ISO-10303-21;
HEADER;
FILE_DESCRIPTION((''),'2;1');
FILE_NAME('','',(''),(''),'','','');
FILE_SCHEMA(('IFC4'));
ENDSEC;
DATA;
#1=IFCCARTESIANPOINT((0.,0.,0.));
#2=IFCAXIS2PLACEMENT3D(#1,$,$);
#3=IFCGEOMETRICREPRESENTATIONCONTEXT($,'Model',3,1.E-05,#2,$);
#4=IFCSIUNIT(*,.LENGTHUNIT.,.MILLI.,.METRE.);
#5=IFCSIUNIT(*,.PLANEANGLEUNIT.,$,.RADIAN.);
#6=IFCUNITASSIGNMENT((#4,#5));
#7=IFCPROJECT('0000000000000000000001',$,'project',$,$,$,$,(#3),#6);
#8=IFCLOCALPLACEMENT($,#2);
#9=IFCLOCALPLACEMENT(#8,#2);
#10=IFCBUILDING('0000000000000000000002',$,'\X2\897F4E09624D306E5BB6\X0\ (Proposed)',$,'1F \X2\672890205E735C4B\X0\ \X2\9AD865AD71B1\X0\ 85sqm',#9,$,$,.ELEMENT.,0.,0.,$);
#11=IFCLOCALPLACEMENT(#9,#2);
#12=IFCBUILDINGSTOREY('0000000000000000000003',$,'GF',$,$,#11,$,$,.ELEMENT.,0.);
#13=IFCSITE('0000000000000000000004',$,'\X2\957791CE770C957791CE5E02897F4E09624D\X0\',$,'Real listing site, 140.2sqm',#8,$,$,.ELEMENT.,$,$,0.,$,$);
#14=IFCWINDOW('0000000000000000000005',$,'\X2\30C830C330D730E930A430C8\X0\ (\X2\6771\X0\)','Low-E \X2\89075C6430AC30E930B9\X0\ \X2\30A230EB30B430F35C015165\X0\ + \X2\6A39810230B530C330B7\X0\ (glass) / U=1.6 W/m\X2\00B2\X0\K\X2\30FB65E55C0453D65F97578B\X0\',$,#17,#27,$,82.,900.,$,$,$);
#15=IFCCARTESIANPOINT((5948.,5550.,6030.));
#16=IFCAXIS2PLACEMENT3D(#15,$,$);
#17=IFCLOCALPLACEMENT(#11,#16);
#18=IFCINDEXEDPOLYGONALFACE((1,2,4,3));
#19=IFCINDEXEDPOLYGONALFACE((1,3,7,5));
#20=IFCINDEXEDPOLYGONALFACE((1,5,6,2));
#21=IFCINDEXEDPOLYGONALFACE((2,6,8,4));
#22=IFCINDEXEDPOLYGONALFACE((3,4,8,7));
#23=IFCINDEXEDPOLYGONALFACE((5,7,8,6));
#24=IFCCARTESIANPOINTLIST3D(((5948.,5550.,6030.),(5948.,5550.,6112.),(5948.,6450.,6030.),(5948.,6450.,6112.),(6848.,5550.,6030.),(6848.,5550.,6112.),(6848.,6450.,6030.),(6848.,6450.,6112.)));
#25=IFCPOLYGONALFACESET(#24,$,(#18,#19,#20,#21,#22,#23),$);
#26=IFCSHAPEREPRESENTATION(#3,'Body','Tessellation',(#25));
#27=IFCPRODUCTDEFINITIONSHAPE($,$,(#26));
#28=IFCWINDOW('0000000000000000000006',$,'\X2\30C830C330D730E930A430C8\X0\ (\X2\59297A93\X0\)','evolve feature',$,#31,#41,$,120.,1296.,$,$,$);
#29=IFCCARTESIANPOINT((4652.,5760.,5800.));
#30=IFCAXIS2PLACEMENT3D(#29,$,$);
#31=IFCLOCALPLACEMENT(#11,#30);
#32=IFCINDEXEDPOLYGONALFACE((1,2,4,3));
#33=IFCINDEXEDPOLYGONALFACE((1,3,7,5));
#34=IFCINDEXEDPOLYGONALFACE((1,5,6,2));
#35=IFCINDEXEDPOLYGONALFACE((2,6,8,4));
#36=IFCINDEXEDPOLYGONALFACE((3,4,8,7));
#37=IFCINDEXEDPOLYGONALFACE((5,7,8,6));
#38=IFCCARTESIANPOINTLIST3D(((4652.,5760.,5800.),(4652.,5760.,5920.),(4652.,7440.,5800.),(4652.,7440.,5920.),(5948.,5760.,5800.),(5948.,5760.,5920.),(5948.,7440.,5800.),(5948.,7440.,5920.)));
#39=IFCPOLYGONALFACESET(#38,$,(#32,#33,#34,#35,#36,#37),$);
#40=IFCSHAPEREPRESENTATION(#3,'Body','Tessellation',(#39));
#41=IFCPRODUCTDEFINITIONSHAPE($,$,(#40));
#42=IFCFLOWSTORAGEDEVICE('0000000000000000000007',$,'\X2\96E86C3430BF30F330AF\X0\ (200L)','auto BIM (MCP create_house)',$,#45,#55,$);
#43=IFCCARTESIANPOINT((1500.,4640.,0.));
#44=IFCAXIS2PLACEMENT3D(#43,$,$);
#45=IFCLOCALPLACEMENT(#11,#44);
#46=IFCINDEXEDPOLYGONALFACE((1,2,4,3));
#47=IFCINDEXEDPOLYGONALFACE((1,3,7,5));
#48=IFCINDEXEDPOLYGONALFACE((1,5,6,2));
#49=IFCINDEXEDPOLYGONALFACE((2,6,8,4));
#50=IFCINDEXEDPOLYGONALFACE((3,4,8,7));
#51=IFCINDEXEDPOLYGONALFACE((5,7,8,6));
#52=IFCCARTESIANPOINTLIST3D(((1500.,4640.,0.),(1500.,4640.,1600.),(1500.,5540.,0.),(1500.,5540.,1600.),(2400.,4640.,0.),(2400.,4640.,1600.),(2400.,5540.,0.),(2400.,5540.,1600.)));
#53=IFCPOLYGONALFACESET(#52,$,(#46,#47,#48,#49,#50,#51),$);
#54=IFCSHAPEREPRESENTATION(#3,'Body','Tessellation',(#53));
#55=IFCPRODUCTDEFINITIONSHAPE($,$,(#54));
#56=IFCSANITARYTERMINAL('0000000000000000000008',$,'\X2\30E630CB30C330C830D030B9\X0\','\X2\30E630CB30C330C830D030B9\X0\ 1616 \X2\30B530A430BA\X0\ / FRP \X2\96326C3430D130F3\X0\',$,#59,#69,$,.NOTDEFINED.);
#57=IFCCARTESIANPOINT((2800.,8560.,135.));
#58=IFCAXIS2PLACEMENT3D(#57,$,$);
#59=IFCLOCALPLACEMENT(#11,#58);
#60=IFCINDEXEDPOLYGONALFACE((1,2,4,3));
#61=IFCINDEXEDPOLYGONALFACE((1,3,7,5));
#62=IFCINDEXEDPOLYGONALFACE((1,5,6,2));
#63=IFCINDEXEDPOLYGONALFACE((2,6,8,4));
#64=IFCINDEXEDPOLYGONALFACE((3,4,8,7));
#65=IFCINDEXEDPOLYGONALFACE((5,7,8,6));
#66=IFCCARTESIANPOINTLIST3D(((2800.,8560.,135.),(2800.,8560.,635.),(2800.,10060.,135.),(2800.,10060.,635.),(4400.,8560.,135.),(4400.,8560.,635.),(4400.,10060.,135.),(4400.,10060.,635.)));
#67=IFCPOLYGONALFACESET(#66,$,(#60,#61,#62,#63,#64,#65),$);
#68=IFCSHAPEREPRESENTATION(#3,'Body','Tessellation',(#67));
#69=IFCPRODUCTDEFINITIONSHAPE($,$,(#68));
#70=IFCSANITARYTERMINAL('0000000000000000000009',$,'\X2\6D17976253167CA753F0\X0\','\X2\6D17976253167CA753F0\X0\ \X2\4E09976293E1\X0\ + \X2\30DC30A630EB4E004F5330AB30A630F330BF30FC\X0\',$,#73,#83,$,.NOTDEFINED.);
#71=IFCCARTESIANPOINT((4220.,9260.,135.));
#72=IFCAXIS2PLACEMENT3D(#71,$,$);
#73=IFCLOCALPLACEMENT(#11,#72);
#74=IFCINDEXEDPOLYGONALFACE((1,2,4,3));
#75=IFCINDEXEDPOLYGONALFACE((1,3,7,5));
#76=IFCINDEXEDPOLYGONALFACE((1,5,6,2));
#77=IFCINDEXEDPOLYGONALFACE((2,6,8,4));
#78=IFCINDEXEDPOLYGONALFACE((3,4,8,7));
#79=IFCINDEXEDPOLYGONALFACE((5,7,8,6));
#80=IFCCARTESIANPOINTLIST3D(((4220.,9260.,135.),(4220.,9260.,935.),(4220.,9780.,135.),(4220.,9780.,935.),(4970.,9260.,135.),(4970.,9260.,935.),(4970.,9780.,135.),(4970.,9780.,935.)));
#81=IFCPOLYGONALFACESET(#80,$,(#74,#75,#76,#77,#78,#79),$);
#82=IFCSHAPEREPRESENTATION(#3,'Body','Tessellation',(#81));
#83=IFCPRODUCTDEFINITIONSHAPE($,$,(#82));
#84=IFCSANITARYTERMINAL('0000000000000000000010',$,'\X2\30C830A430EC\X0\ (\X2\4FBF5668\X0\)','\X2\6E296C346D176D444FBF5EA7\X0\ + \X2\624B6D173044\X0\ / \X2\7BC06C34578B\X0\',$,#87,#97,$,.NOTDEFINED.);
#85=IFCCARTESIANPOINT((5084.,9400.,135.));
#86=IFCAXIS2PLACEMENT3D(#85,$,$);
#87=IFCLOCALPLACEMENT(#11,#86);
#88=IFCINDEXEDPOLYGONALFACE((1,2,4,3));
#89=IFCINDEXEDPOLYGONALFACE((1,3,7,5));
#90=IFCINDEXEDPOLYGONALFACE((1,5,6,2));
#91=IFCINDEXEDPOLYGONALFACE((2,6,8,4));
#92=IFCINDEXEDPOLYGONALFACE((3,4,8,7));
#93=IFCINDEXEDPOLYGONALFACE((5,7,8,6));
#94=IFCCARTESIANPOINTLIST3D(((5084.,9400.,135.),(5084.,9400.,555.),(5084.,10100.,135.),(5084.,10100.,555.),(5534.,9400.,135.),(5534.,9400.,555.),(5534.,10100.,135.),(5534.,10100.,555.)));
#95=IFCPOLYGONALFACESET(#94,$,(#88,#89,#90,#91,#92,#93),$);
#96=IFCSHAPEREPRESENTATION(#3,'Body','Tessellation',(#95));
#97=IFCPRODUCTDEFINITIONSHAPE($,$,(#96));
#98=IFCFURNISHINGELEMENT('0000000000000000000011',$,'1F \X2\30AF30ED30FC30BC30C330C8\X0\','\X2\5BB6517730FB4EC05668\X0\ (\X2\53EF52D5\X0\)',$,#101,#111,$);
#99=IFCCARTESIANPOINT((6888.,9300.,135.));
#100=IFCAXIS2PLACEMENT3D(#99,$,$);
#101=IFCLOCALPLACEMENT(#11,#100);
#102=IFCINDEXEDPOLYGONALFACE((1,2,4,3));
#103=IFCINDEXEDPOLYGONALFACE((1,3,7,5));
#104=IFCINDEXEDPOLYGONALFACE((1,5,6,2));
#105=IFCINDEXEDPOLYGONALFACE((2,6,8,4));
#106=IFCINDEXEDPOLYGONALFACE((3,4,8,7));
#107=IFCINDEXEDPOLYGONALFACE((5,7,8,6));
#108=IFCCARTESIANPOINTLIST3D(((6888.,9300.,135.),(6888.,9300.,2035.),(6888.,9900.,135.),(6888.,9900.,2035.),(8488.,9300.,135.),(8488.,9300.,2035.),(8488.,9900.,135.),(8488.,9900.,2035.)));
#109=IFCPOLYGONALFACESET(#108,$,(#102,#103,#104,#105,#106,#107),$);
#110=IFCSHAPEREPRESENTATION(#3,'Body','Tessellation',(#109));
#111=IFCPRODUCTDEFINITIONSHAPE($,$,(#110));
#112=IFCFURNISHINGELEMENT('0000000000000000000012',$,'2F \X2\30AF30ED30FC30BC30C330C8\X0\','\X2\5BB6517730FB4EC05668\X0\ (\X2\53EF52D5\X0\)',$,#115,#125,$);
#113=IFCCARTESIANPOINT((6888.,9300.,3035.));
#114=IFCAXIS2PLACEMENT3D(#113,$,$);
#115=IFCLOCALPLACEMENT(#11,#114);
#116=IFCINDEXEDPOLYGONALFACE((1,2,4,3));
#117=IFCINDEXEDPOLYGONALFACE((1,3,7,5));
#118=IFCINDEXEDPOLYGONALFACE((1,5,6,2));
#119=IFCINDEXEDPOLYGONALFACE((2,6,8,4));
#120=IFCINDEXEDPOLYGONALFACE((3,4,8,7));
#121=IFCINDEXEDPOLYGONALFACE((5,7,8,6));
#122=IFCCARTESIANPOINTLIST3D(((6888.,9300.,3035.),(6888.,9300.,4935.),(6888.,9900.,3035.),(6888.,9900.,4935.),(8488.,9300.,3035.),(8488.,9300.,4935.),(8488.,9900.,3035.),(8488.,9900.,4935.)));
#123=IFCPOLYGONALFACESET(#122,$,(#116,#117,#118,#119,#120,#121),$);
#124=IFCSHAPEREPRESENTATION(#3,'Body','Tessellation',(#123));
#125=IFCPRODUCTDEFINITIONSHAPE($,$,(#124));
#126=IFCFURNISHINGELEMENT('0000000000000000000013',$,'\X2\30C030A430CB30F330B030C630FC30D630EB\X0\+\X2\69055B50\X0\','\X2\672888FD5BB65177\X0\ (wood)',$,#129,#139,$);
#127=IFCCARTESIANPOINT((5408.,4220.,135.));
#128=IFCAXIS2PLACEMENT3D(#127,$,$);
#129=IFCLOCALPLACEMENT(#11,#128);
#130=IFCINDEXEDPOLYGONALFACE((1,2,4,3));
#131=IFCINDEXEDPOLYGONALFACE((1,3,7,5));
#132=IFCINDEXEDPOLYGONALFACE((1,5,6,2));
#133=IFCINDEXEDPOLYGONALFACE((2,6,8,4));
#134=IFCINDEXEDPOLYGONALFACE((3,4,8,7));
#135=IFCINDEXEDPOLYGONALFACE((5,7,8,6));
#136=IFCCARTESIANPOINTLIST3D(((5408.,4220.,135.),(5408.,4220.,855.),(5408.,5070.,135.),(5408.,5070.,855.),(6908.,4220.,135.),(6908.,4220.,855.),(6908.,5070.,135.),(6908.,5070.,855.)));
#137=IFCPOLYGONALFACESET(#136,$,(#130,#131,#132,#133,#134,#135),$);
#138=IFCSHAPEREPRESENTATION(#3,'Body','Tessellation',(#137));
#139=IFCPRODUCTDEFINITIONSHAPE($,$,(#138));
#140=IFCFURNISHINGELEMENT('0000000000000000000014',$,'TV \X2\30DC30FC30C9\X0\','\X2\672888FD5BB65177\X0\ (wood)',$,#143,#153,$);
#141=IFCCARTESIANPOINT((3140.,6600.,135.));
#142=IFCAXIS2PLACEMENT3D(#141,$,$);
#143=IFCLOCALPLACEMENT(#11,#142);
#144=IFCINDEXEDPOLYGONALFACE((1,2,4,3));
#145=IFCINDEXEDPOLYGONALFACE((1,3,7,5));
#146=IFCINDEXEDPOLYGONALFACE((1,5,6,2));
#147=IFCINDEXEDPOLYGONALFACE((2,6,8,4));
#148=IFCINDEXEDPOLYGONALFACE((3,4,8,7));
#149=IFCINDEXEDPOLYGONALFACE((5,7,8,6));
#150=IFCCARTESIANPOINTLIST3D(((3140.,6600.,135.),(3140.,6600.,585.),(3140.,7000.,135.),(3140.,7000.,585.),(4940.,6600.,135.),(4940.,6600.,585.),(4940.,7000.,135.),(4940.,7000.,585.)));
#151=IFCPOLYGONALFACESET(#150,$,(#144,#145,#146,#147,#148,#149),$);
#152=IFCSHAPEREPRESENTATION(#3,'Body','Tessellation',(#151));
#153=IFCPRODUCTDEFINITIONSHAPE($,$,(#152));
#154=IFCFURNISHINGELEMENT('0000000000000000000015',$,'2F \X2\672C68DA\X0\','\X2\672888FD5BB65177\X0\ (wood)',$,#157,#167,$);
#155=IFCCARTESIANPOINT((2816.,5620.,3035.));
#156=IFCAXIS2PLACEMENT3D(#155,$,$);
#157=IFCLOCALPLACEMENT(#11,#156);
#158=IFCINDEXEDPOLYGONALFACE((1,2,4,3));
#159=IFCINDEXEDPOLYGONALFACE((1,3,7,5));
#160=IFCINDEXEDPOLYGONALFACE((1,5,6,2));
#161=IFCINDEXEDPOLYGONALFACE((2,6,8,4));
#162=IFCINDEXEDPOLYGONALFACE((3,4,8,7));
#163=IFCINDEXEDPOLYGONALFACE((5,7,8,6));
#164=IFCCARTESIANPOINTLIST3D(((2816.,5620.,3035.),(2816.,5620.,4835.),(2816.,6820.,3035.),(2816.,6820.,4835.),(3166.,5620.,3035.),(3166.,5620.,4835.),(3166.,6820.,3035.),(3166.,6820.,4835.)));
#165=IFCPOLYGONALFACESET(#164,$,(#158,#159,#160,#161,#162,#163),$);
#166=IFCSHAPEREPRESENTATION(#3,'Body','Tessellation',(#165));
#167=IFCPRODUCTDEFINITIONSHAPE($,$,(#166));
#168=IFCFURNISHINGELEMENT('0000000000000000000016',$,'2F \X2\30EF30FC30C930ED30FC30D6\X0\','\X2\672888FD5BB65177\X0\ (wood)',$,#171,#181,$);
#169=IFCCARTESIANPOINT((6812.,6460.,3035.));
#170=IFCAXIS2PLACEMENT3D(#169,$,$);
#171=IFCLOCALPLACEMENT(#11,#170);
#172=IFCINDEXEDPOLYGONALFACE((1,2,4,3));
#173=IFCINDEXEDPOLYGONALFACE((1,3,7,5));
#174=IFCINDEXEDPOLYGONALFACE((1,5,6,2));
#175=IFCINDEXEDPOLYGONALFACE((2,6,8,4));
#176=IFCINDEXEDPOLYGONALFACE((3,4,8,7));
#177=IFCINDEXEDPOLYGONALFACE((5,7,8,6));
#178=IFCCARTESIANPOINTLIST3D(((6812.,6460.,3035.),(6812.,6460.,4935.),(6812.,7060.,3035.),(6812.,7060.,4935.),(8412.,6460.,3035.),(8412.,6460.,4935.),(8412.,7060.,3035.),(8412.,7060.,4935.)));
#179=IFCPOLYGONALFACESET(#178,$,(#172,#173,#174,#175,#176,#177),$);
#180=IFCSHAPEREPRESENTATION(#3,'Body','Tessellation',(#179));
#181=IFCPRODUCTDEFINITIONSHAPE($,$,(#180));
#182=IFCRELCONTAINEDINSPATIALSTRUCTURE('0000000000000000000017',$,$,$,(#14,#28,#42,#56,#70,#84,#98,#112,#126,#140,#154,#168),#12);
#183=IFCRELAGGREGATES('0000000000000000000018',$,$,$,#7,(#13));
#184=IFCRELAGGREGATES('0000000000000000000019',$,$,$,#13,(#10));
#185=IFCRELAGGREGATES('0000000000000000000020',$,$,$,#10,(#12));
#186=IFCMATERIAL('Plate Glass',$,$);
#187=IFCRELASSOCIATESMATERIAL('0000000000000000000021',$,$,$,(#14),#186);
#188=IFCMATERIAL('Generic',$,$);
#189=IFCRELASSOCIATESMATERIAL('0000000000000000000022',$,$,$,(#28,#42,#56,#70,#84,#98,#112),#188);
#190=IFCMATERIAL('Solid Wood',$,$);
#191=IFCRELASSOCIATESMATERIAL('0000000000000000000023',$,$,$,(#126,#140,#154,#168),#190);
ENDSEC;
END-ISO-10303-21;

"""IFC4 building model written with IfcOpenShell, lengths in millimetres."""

from ifc_helpers import new_model, si_unit, frame, frame_2d, origin, place, context, project, spatial, rectangle, extrude, material, element, save


model = new_model("IFC4")

# Units and contexts
model_context = context("Model", 3, precision=1e-05, world=origin())
ifc_project = project(units=[si_unit("LENGTHUNIT", "METRE", prefix="MILLI"), si_unit("PLANEANGLEUNIT", "RADIAN")], contexts=[model_context])

# Site, building, storey
site_placement = place(None, origin())
site = spatial("IfcSite", under=ifc_project, at=site_placement, Name="長野県長野市西三才", ObjectType="Real listing site, 140.2sqm", CompositionType="ELEMENT", RefElevation=0.0)
building_placement = place(site_placement, origin())
building = spatial("IfcBuilding", under=site, at=building_placement, Name="西三才の家 (Proposed)", ObjectType="1F 木造平屋 高断熱 85sqm", CompositionType="ELEMENT", ElevationOfRefHeight=0.0, ElevationOfTerrain=0.0)
storey_placement = place(building_placement, origin())
storey = spatial("IfcBuildingStorey", under=building, at=storey_placement, Name="GF", CompositionType="ELEMENT", Elevation=0.0)

# Shared definitions
ifc_material_1 = material(Name="Solid Wood")
ifc_material_2 = material(Name="Plate Glass")

# Windows
window_1_placement = place(storey_placement, frame((5948.0, 5550.0, 6030.0)))
element("IfcWindow", 1, at=window_1_placement, inside=storey, material=ifc_material_2, Name="トップライト (東)", Description="Low-E 複層ガラス アルゴン封入 + 樹脂サッシ (glass) / U=1.6 W/m²K・日射取得型", OverallHeight=82.0, OverallWidth=900.0, context=model_context, shape_type="SweptSolid", body=[
    extrude(rectangle(XDim=900.0, YDim=900.0, at=frame_2d((450.0, 450.0))), frame((5948.0, 5550.0, 6030.0)), (0.0, 0.0, 1.0), 82.0),
])
ifc_material_3 = material(Name="Generic")
window_2_placement = place(storey_placement, frame((4652.0, 5760.0, 5800.0)))
element("IfcWindow", 2, at=window_2_placement, inside=storey, material=ifc_material_3, Name="トップライト (天窓)", Description="evolve feature", OverallHeight=120.0, OverallWidth=1296.0, context=model_context, shape_type="SweptSolid", body=[
    extrude(rectangle(XDim=1296.0, YDim=1680.0, at=frame_2d((648.0, 840.0))), frame((4652.0, 5760.0, 5800.0)), (0.0, 0.0, 1.0), 120.0),
])

# Flow storage device
flow_storage_device_placement = place(storey_placement, frame((1500.0, 4640.0, 0.0)))
element("IfcFlowStorageDevice", 3, at=flow_storage_device_placement, inside=storey, material=ifc_material_3, Name="雨水タンク (200L)", Description="auto BIM (MCP create_house)", context=model_context, shape_type="SweptSolid", body=[
    extrude(rectangle(XDim=900.0, YDim=900.0, at=frame_2d((450.0, 450.0))), frame((1500.0, 4640.0, 0.0)), (0.0, 0.0, 1.0), 1600.0),
])

# Sanitary terminals
sanitary_terminal_1_placement = place(storey_placement, frame((2800.0, 8560.0, 135.0)))
element("IfcSanitaryTerminal", 4, at=sanitary_terminal_1_placement, inside=storey, material=ifc_material_3, Name="ユニットバス", Description="ユニットバス 1616 サイズ / FRP 防水パン", PredefinedType="NOTDEFINED", context=model_context, shape_type="SweptSolid", body=[
    extrude(rectangle(XDim=1600.0, YDim=1500.0, at=frame_2d((800.0, 750.0))), frame((2800.0, 8560.0, 135.0)), (0.0, 0.0, 1.0), 500.0),
])
sanitary_terminal_2_placement = place(storey_placement, frame((4220.0, 9260.0, 135.0)))
element("IfcSanitaryTerminal", 5, at=sanitary_terminal_2_placement, inside=storey, material=ifc_material_3, Name="洗面化粧台", Description="洗面化粧台 三面鏡 + ボウル一体カウンター", PredefinedType="NOTDEFINED", context=model_context, shape_type="SweptSolid", body=[
    extrude(rectangle(XDim=750.0, YDim=520.0, at=frame_2d((375.0, 260.0))), frame((4220.0, 9260.0, 135.0)), (0.0, 0.0, 1.0), 800.0),
])
sanitary_terminal_3_placement = place(storey_placement, frame((5084.0, 9400.0, 135.0)))
element("IfcSanitaryTerminal", 6, at=sanitary_terminal_3_placement, inside=storey, material=ifc_material_3, Name="トイレ (便器)", Description="温水洗浄便座 + 手洗い / 節水型", PredefinedType="NOTDEFINED", context=model_context, shape_type="SweptSolid", body=[
    extrude(rectangle(XDim=450.0, YDim=700.0, at=frame_2d((225.0, 350.0))), frame((5084.0, 9400.0, 135.0)), (0.0, 0.0, 1.0), 420.0),
])

# Furnishing elements
furnishing_1_placement = place(storey_placement, frame((6888.0, 9300.0, 135.0)))
element("IfcFurnishingElement", 7, at=furnishing_1_placement, inside=storey, material=ifc_material_3, Name="1F クローゼット", Description="家具・什器 (可動)", context=model_context, shape_type="SweptSolid", body=[
    extrude(rectangle(XDim=1600.0, YDim=600.0, at=frame_2d((800.0, 300.0))), frame((6888.0, 9300.0, 135.0)), (0.0, 0.0, 1.0), 1900.0),
])
furnishing_2_placement = place(storey_placement, frame((6888.0, 9300.0, 3035.0)))
element("IfcFurnishingElement", 8, at=furnishing_2_placement, inside=storey, material=ifc_material_3, Name="2F クローゼット", Description="家具・什器 (可動)", context=model_context, shape_type="SweptSolid", body=[
    extrude(rectangle(XDim=1600.0, YDim=600.0, at=frame_2d((800.0, 300.0))), frame((6888.0, 9300.0, 3035.0)), (0.0, 0.0, 1.0), 1900.0),
])
furnishing_3_placement = place(storey_placement, frame((5408.0, 4220.0, 135.0)))
element("IfcFurnishingElement", 9, at=furnishing_3_placement, inside=storey, material=ifc_material_1, Name="ダイニングテーブル+椅子", Description="木製家具 (wood)", context=model_context, shape_type="SweptSolid", body=[
    extrude(rectangle(XDim=1500.0, YDim=850.0, at=frame_2d((750.0, 425.0))), frame((5408.0, 4220.0, 135.0)), (0.0, 0.0, 1.0), 720.0),
])
furnishing_4_placement = place(storey_placement, frame((3140.0, 6600.0, 135.0)))
element("IfcFurnishingElement", 10, at=furnishing_4_placement, inside=storey, material=ifc_material_1, Name="TV ボード", Description="木製家具 (wood)", context=model_context, shape_type="SweptSolid", body=[
    extrude(rectangle(XDim=1800.0, YDim=400.0, at=frame_2d((900.0, 200.0))), frame((3140.0, 6600.0, 135.0)), (0.0, 0.0, 1.0), 450.0),
])
furnishing_5_placement = place(storey_placement, frame((2816.0, 5620.0, 3035.0)))
element("IfcFurnishingElement", 11, at=furnishing_5_placement, inside=storey, material=ifc_material_1, Name="2F 本棚", Description="木製家具 (wood)", context=model_context, shape_type="SweptSolid", body=[
    extrude(rectangle(XDim=350.0, YDim=1200.0, at=frame_2d((175.0, 600.0))), frame((2816.0, 5620.0, 3035.0)), (0.0, 0.0, 1.0), 1800.0),
])
furnishing_6_placement = place(storey_placement, frame((6812.0, 6460.0, 3035.0)))
element("IfcFurnishingElement", 12, at=furnishing_6_placement, inside=storey, material=ifc_material_1, Name="2F ワードローブ", Description="木製家具 (wood)", context=model_context, shape_type="SweptSolid", body=[
    extrude(rectangle(XDim=1600.0, YDim=600.0, at=frame_2d((800.0, 300.0))), frame((6812.0, 6460.0, 3035.0)), (0.0, 0.0, 1.0), 1900.0),
])

save(model, "model.ifc")
